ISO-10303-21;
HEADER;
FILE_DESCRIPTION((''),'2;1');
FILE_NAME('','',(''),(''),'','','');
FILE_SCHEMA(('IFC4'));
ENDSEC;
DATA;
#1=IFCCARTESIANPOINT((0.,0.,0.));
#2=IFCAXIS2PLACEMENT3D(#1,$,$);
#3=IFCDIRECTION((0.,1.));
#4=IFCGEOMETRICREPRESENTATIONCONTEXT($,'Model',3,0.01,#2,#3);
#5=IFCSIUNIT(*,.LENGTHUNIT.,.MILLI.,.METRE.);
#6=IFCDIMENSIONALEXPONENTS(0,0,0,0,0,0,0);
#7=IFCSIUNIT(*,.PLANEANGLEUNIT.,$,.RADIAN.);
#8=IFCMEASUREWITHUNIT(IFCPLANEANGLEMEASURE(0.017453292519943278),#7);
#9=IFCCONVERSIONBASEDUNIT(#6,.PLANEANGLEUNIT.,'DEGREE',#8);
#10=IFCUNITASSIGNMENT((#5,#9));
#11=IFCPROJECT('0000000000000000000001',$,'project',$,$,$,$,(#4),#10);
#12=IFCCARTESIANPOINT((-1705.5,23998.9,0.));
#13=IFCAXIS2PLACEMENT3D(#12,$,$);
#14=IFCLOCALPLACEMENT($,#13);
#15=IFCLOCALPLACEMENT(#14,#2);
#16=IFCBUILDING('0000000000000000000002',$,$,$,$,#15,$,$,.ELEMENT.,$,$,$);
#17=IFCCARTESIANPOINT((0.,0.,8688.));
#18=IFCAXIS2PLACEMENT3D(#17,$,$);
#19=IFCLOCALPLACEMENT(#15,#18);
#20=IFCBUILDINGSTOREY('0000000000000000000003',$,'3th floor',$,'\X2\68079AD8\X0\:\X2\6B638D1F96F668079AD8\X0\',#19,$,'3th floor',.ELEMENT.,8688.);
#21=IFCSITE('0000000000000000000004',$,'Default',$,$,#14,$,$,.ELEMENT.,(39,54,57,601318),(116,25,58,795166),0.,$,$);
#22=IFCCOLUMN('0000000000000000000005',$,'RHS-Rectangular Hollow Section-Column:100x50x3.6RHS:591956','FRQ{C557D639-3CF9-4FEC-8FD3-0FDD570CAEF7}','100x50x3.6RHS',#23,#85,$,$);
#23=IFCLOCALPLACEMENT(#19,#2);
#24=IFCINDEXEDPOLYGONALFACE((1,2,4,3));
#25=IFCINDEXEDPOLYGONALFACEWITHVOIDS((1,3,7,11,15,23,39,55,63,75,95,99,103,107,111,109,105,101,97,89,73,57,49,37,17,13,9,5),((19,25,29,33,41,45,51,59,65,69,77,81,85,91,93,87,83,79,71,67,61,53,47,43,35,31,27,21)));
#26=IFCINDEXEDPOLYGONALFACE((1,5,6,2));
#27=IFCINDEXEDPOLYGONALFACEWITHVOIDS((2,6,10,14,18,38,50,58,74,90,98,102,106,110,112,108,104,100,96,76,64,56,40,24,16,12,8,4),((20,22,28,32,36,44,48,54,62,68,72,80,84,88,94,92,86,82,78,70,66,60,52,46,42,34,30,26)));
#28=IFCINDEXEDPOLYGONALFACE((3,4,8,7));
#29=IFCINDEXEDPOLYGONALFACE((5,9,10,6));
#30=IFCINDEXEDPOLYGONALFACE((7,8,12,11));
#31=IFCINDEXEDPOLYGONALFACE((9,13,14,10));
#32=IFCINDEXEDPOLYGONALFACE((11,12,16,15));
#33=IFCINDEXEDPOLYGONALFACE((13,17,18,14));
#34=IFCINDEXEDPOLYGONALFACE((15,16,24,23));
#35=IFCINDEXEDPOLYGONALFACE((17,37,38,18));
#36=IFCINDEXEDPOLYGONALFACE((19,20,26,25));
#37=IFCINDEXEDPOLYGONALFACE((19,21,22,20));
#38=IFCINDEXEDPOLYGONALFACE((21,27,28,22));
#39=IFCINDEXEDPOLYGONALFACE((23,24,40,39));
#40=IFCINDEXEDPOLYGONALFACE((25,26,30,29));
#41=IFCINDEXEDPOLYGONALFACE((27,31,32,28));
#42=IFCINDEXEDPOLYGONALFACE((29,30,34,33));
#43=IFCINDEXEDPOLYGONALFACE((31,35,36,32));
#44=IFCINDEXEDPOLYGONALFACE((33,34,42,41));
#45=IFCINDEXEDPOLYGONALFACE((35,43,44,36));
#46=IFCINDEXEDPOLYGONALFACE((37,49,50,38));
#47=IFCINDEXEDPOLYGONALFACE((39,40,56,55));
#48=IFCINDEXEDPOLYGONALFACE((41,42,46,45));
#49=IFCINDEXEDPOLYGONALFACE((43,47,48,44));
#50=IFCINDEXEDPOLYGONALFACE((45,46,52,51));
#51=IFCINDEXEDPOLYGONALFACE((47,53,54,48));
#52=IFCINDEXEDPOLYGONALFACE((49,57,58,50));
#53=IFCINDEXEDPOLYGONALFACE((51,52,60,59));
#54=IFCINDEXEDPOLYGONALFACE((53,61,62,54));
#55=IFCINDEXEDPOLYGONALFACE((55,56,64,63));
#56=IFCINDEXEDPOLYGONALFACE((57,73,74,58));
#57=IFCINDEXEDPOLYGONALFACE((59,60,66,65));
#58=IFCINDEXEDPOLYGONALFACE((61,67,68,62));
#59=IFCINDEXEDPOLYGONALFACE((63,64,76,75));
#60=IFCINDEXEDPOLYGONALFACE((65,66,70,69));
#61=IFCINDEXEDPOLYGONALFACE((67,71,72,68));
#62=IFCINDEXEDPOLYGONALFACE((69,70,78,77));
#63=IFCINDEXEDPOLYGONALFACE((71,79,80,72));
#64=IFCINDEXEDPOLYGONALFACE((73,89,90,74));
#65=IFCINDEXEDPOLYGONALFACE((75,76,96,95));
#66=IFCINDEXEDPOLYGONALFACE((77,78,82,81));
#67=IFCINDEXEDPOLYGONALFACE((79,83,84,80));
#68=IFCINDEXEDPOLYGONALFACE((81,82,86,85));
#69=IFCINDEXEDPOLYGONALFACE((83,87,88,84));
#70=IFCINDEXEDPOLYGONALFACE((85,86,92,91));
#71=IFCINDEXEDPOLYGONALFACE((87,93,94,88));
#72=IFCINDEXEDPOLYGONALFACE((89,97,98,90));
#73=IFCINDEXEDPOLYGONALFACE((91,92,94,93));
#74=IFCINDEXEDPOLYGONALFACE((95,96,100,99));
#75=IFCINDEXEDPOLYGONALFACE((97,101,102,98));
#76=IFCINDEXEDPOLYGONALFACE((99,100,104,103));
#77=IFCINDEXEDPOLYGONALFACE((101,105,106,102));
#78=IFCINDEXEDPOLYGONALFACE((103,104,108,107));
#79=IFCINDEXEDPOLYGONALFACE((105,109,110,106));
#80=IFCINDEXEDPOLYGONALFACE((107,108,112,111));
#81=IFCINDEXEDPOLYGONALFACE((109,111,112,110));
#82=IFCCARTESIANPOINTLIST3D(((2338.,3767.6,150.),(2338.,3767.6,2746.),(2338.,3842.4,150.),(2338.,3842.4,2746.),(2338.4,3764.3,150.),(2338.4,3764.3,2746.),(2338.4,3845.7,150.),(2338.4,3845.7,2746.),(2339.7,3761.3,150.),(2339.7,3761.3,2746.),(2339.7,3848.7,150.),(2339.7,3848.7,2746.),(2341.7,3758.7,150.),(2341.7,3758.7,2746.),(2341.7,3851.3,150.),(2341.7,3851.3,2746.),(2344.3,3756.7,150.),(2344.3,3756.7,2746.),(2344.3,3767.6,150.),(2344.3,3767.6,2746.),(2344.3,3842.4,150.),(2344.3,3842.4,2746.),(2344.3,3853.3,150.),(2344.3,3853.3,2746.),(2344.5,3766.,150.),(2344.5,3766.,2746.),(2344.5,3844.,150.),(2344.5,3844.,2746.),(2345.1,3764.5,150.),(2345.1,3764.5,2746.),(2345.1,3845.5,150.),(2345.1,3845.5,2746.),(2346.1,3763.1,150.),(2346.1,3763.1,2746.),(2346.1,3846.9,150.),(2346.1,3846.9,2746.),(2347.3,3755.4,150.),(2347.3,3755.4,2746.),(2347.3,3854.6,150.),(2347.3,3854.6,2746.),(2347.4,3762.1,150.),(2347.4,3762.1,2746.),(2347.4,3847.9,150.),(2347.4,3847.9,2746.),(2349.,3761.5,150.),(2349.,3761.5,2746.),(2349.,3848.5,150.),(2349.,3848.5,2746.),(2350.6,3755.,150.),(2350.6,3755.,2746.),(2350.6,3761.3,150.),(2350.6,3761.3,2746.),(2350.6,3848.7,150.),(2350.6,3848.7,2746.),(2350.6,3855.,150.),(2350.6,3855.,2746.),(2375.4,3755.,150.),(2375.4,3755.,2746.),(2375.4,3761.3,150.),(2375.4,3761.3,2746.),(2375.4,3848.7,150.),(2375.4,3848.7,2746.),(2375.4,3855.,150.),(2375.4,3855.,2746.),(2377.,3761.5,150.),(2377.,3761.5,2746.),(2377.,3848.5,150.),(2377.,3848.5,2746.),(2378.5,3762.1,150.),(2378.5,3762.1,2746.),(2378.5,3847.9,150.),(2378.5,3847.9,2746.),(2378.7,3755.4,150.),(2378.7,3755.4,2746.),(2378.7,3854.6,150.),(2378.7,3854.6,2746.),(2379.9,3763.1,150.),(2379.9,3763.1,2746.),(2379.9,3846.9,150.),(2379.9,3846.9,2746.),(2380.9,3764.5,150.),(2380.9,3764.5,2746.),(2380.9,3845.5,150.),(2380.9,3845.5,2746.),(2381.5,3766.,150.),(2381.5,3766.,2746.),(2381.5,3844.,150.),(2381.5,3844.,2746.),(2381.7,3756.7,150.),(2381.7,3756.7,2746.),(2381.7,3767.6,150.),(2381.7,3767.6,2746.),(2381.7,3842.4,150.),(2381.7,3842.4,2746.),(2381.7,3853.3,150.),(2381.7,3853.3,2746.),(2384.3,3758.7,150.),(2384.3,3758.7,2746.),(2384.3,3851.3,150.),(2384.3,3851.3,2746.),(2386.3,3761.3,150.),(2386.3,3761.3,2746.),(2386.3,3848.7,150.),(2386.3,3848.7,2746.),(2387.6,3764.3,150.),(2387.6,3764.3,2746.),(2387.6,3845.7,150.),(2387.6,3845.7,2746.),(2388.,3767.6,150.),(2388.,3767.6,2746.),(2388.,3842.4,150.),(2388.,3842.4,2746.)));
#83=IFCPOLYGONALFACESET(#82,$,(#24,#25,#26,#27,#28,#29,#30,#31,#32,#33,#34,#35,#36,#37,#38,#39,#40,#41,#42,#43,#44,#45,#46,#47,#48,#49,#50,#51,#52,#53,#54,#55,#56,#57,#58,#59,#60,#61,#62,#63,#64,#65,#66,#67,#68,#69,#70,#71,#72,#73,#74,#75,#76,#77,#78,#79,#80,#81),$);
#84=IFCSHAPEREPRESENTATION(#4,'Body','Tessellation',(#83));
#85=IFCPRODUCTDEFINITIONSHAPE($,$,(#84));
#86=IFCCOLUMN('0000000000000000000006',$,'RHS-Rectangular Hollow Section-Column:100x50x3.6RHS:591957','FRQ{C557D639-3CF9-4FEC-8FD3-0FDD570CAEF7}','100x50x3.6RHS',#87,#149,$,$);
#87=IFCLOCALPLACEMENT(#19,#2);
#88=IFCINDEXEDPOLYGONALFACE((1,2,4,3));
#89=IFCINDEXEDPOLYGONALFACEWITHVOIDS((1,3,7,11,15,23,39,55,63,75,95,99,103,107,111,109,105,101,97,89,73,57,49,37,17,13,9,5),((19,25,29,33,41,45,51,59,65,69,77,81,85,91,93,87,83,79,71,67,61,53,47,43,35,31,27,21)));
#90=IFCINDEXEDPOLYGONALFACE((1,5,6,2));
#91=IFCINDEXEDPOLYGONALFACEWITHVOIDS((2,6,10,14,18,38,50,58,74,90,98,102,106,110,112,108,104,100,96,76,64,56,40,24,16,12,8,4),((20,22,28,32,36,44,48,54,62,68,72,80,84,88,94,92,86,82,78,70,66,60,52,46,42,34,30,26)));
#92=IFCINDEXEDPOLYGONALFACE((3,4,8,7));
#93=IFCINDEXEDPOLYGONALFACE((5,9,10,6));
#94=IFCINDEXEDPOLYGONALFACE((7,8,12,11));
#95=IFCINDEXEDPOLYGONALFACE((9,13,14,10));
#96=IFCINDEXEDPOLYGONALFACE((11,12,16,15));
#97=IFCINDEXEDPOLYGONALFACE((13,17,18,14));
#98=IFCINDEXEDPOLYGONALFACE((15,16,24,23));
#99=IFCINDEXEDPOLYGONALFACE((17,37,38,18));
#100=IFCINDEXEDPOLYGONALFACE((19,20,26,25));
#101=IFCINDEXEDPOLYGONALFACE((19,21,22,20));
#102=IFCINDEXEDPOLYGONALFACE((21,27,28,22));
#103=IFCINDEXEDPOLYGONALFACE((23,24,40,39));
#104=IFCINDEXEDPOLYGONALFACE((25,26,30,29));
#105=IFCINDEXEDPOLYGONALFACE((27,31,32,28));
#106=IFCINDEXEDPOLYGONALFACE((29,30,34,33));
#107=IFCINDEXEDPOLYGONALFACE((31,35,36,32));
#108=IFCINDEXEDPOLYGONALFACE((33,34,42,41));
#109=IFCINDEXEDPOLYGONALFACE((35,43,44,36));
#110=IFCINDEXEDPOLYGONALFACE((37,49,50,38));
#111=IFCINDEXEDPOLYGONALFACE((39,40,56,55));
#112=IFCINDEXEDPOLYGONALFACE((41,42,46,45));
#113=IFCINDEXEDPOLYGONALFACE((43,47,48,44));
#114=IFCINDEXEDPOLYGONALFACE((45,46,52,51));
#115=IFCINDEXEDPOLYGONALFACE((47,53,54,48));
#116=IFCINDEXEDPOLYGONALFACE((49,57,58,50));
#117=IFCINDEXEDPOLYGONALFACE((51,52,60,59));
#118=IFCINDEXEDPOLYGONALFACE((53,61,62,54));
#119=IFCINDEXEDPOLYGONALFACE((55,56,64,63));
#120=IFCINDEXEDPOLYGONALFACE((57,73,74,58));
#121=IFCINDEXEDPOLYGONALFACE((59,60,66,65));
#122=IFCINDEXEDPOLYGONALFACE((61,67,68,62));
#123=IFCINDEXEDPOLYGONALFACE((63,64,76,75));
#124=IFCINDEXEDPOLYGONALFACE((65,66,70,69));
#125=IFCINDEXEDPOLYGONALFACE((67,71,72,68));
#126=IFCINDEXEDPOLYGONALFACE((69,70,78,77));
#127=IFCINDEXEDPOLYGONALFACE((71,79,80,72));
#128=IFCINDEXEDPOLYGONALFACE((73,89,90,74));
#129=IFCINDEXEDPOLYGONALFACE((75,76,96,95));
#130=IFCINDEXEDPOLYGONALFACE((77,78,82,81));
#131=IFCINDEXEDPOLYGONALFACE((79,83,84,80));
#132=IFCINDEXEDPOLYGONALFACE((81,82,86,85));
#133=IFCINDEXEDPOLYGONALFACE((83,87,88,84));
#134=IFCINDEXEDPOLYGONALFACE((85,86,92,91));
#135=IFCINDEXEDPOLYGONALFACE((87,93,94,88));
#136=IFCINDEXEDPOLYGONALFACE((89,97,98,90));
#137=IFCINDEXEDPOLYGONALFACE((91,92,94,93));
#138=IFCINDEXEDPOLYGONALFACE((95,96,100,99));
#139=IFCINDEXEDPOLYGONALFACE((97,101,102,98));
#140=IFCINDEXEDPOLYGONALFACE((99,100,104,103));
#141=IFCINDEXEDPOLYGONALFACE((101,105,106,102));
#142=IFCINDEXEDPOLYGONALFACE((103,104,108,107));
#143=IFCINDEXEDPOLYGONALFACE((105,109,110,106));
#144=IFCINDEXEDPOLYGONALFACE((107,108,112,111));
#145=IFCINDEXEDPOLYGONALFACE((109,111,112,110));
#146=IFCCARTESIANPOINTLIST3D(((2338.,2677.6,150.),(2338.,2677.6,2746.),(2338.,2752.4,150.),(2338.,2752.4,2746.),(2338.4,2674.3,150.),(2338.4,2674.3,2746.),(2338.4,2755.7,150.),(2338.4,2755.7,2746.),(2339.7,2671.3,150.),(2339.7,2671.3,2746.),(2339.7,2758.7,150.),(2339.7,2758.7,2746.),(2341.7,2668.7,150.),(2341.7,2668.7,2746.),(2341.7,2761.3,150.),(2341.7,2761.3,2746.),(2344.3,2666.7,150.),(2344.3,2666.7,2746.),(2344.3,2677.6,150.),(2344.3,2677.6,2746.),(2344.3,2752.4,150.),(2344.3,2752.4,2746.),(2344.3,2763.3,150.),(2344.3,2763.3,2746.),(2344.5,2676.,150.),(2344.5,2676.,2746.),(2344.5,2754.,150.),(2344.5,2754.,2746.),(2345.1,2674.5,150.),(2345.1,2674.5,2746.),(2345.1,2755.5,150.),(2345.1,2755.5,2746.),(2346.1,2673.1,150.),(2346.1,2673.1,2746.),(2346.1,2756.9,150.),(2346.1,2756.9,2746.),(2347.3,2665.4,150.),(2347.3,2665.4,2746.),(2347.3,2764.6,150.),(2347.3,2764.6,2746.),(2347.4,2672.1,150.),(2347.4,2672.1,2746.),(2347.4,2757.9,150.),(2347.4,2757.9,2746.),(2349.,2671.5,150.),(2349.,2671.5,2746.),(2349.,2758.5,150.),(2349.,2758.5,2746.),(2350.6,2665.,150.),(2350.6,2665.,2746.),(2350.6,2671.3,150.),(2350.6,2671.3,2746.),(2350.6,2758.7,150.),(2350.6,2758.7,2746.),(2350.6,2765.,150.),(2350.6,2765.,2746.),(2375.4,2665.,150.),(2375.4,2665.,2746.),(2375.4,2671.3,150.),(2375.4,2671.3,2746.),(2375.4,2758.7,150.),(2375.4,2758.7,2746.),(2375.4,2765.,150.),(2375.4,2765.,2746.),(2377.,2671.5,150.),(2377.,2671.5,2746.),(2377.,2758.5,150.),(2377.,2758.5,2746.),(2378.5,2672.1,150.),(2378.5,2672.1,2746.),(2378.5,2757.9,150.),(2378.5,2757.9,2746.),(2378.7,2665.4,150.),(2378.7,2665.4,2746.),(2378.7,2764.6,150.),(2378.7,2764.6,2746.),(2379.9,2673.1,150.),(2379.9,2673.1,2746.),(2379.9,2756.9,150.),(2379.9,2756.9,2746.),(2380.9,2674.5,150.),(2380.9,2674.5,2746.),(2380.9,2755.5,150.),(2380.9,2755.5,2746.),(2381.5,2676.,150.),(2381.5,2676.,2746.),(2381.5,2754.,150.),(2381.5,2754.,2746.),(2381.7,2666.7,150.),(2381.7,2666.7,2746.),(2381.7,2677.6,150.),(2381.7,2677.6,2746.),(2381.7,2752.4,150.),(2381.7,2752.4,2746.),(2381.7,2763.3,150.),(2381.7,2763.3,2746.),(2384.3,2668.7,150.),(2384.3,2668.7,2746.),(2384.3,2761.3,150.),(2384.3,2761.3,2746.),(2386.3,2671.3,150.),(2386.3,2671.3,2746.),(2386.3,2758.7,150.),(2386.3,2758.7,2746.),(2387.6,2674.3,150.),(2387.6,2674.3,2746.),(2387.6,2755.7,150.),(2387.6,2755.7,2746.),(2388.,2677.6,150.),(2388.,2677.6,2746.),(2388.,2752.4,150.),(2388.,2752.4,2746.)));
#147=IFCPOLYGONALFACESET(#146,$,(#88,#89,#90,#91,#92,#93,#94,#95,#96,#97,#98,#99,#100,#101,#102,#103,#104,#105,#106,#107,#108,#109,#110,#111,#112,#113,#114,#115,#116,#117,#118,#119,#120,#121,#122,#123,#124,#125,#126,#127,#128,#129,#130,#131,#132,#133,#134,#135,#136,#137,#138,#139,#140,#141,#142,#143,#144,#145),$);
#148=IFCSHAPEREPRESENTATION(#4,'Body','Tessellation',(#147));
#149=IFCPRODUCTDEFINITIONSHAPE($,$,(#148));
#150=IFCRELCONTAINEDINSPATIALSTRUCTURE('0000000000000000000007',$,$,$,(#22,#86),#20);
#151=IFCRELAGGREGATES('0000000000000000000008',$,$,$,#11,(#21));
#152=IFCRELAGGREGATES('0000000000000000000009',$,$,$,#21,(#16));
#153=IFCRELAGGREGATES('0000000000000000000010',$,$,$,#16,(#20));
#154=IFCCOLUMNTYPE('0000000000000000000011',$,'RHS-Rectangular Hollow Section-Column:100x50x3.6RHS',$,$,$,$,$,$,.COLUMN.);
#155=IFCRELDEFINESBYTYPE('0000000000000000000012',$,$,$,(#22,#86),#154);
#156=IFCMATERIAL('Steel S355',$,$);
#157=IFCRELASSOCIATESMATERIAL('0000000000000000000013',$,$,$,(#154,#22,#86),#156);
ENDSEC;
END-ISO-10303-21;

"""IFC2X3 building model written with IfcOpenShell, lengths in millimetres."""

from ifc_helpers import new_model, entity, si_unit, converted_unit, direction, frame, origin, origin_2d, place, context, project, spatial, hollow_rectangle, extrude, clip, halfspace, material, type_object, element, save


model = new_model("IFC2X3")

# Units and contexts
model_context = context("Model", 3, precision=0.01, world=origin(), true_north=direction((0.0, 1.0)))
ifc_project = project(units=[si_unit("LENGTHUNIT", "METRE", prefix="MILLI"), converted_unit("PLANEANGLEUNIT", "DEGREE", entity("IfcPlaneAngleMeasure", 0.017453292519943278), si_unit("PLANEANGLEUNIT", "RADIAN"), dimensions=[0, 0, 0, 0, 0, 0, 0])], contexts=[model_context])

# Site, building, storey
site_placement = place(None, frame((-1705.5, 23998.9, 0.0)))
site = spatial("IfcSite", under=ifc_project, at=site_placement, Name="Default", CompositionType="ELEMENT", RefLatitude=(39, 54, 57, 601318), RefLongitude=(116, 25, 58, 795166), RefElevation=0.0)
building_placement = place(site_placement, origin())
building = spatial("IfcBuilding", under=site, at=building_placement, CompositionType="ELEMENT")
storey_placement = place(building_placement, frame((0.0, 0.0, 8688.0)))
storey = spatial("IfcBuildingStorey", under=building, at=storey_placement, Name="3th floor", ObjectType="标高:正负零标高", LongName="3th floor", CompositionType="ELEMENT", Elevation=8688.0)

# Shared definitions
ifc_material_1 = material(Name="Steel S355")

# Columns
column_type_1 = type_object("IfcColumnType", Name="RHS-Rectangular Hollow Section-Column:100x50x3.6RHS", PredefinedType="COLUMN", material=ifc_material_1)
column_1_placement = place(storey_placement, frame((2363.0, 3805.0, 2746.0), z_axis=(0.0, 0.0, 1.0), x_axis=(-1.0, 0.0, 0.0)))
element("IfcColumn", 1, at=column_1_placement, inside=storey, type_object=column_type_1, material=ifc_material_1, Name="RHS-Rectangular Hollow Section-Column:100x50x3.6RHS:591956", Description="FRQ{C557D639-3CF9-4FEC-8FD3-0FDD570CAEF7}", ObjectType="100x50x3.6RHS", context=model_context, shape_type="Clipping", body=[
    clip(extrude(hollow_rectangle(XDim=50.0, YDim=100.0, WallThickness=6.3, InnerFilletRadius=6.3, OuterFilletRadius=12.6, at=origin_2d()), origin(), (0.0, 0.0, -1.0), 2651.9), halfspace(frame((2363.0, 3805.0, -2596.0), z_axis=(0.0, 0.0, 1.0), x_axis=(-1.0, 0.0, 0.0)), True)),
])
column_2_placement = place(storey_placement, frame((2363.0, 2715.0, 2746.0), z_axis=(0.0, 0.0, 1.0), x_axis=(-1.0, 0.0, 0.0)))
element("IfcColumn", 2, at=column_2_placement, inside=storey, type_object=column_type_1, material=ifc_material_1, Name="RHS-Rectangular Hollow Section-Column:100x50x3.6RHS:591957", Description="FRQ{C557D639-3CF9-4FEC-8FD3-0FDD570CAEF7}", ObjectType="100x50x3.6RHS", context=model_context, shape_type="Clipping", body=[
    clip(extrude(hollow_rectangle(XDim=50.0, YDim=100.0, WallThickness=6.3, InnerFilletRadius=6.3, OuterFilletRadius=12.6, at=origin_2d()), origin(), (0.0, 0.0, -1.0), 2651.9), halfspace(frame((2363.0, 2715.0, -2596.0), z_axis=(0.0, 0.0, 1.0), x_axis=(-1.0, 0.0, 0.0)), True)),
])

save(model, "model.ifc")
